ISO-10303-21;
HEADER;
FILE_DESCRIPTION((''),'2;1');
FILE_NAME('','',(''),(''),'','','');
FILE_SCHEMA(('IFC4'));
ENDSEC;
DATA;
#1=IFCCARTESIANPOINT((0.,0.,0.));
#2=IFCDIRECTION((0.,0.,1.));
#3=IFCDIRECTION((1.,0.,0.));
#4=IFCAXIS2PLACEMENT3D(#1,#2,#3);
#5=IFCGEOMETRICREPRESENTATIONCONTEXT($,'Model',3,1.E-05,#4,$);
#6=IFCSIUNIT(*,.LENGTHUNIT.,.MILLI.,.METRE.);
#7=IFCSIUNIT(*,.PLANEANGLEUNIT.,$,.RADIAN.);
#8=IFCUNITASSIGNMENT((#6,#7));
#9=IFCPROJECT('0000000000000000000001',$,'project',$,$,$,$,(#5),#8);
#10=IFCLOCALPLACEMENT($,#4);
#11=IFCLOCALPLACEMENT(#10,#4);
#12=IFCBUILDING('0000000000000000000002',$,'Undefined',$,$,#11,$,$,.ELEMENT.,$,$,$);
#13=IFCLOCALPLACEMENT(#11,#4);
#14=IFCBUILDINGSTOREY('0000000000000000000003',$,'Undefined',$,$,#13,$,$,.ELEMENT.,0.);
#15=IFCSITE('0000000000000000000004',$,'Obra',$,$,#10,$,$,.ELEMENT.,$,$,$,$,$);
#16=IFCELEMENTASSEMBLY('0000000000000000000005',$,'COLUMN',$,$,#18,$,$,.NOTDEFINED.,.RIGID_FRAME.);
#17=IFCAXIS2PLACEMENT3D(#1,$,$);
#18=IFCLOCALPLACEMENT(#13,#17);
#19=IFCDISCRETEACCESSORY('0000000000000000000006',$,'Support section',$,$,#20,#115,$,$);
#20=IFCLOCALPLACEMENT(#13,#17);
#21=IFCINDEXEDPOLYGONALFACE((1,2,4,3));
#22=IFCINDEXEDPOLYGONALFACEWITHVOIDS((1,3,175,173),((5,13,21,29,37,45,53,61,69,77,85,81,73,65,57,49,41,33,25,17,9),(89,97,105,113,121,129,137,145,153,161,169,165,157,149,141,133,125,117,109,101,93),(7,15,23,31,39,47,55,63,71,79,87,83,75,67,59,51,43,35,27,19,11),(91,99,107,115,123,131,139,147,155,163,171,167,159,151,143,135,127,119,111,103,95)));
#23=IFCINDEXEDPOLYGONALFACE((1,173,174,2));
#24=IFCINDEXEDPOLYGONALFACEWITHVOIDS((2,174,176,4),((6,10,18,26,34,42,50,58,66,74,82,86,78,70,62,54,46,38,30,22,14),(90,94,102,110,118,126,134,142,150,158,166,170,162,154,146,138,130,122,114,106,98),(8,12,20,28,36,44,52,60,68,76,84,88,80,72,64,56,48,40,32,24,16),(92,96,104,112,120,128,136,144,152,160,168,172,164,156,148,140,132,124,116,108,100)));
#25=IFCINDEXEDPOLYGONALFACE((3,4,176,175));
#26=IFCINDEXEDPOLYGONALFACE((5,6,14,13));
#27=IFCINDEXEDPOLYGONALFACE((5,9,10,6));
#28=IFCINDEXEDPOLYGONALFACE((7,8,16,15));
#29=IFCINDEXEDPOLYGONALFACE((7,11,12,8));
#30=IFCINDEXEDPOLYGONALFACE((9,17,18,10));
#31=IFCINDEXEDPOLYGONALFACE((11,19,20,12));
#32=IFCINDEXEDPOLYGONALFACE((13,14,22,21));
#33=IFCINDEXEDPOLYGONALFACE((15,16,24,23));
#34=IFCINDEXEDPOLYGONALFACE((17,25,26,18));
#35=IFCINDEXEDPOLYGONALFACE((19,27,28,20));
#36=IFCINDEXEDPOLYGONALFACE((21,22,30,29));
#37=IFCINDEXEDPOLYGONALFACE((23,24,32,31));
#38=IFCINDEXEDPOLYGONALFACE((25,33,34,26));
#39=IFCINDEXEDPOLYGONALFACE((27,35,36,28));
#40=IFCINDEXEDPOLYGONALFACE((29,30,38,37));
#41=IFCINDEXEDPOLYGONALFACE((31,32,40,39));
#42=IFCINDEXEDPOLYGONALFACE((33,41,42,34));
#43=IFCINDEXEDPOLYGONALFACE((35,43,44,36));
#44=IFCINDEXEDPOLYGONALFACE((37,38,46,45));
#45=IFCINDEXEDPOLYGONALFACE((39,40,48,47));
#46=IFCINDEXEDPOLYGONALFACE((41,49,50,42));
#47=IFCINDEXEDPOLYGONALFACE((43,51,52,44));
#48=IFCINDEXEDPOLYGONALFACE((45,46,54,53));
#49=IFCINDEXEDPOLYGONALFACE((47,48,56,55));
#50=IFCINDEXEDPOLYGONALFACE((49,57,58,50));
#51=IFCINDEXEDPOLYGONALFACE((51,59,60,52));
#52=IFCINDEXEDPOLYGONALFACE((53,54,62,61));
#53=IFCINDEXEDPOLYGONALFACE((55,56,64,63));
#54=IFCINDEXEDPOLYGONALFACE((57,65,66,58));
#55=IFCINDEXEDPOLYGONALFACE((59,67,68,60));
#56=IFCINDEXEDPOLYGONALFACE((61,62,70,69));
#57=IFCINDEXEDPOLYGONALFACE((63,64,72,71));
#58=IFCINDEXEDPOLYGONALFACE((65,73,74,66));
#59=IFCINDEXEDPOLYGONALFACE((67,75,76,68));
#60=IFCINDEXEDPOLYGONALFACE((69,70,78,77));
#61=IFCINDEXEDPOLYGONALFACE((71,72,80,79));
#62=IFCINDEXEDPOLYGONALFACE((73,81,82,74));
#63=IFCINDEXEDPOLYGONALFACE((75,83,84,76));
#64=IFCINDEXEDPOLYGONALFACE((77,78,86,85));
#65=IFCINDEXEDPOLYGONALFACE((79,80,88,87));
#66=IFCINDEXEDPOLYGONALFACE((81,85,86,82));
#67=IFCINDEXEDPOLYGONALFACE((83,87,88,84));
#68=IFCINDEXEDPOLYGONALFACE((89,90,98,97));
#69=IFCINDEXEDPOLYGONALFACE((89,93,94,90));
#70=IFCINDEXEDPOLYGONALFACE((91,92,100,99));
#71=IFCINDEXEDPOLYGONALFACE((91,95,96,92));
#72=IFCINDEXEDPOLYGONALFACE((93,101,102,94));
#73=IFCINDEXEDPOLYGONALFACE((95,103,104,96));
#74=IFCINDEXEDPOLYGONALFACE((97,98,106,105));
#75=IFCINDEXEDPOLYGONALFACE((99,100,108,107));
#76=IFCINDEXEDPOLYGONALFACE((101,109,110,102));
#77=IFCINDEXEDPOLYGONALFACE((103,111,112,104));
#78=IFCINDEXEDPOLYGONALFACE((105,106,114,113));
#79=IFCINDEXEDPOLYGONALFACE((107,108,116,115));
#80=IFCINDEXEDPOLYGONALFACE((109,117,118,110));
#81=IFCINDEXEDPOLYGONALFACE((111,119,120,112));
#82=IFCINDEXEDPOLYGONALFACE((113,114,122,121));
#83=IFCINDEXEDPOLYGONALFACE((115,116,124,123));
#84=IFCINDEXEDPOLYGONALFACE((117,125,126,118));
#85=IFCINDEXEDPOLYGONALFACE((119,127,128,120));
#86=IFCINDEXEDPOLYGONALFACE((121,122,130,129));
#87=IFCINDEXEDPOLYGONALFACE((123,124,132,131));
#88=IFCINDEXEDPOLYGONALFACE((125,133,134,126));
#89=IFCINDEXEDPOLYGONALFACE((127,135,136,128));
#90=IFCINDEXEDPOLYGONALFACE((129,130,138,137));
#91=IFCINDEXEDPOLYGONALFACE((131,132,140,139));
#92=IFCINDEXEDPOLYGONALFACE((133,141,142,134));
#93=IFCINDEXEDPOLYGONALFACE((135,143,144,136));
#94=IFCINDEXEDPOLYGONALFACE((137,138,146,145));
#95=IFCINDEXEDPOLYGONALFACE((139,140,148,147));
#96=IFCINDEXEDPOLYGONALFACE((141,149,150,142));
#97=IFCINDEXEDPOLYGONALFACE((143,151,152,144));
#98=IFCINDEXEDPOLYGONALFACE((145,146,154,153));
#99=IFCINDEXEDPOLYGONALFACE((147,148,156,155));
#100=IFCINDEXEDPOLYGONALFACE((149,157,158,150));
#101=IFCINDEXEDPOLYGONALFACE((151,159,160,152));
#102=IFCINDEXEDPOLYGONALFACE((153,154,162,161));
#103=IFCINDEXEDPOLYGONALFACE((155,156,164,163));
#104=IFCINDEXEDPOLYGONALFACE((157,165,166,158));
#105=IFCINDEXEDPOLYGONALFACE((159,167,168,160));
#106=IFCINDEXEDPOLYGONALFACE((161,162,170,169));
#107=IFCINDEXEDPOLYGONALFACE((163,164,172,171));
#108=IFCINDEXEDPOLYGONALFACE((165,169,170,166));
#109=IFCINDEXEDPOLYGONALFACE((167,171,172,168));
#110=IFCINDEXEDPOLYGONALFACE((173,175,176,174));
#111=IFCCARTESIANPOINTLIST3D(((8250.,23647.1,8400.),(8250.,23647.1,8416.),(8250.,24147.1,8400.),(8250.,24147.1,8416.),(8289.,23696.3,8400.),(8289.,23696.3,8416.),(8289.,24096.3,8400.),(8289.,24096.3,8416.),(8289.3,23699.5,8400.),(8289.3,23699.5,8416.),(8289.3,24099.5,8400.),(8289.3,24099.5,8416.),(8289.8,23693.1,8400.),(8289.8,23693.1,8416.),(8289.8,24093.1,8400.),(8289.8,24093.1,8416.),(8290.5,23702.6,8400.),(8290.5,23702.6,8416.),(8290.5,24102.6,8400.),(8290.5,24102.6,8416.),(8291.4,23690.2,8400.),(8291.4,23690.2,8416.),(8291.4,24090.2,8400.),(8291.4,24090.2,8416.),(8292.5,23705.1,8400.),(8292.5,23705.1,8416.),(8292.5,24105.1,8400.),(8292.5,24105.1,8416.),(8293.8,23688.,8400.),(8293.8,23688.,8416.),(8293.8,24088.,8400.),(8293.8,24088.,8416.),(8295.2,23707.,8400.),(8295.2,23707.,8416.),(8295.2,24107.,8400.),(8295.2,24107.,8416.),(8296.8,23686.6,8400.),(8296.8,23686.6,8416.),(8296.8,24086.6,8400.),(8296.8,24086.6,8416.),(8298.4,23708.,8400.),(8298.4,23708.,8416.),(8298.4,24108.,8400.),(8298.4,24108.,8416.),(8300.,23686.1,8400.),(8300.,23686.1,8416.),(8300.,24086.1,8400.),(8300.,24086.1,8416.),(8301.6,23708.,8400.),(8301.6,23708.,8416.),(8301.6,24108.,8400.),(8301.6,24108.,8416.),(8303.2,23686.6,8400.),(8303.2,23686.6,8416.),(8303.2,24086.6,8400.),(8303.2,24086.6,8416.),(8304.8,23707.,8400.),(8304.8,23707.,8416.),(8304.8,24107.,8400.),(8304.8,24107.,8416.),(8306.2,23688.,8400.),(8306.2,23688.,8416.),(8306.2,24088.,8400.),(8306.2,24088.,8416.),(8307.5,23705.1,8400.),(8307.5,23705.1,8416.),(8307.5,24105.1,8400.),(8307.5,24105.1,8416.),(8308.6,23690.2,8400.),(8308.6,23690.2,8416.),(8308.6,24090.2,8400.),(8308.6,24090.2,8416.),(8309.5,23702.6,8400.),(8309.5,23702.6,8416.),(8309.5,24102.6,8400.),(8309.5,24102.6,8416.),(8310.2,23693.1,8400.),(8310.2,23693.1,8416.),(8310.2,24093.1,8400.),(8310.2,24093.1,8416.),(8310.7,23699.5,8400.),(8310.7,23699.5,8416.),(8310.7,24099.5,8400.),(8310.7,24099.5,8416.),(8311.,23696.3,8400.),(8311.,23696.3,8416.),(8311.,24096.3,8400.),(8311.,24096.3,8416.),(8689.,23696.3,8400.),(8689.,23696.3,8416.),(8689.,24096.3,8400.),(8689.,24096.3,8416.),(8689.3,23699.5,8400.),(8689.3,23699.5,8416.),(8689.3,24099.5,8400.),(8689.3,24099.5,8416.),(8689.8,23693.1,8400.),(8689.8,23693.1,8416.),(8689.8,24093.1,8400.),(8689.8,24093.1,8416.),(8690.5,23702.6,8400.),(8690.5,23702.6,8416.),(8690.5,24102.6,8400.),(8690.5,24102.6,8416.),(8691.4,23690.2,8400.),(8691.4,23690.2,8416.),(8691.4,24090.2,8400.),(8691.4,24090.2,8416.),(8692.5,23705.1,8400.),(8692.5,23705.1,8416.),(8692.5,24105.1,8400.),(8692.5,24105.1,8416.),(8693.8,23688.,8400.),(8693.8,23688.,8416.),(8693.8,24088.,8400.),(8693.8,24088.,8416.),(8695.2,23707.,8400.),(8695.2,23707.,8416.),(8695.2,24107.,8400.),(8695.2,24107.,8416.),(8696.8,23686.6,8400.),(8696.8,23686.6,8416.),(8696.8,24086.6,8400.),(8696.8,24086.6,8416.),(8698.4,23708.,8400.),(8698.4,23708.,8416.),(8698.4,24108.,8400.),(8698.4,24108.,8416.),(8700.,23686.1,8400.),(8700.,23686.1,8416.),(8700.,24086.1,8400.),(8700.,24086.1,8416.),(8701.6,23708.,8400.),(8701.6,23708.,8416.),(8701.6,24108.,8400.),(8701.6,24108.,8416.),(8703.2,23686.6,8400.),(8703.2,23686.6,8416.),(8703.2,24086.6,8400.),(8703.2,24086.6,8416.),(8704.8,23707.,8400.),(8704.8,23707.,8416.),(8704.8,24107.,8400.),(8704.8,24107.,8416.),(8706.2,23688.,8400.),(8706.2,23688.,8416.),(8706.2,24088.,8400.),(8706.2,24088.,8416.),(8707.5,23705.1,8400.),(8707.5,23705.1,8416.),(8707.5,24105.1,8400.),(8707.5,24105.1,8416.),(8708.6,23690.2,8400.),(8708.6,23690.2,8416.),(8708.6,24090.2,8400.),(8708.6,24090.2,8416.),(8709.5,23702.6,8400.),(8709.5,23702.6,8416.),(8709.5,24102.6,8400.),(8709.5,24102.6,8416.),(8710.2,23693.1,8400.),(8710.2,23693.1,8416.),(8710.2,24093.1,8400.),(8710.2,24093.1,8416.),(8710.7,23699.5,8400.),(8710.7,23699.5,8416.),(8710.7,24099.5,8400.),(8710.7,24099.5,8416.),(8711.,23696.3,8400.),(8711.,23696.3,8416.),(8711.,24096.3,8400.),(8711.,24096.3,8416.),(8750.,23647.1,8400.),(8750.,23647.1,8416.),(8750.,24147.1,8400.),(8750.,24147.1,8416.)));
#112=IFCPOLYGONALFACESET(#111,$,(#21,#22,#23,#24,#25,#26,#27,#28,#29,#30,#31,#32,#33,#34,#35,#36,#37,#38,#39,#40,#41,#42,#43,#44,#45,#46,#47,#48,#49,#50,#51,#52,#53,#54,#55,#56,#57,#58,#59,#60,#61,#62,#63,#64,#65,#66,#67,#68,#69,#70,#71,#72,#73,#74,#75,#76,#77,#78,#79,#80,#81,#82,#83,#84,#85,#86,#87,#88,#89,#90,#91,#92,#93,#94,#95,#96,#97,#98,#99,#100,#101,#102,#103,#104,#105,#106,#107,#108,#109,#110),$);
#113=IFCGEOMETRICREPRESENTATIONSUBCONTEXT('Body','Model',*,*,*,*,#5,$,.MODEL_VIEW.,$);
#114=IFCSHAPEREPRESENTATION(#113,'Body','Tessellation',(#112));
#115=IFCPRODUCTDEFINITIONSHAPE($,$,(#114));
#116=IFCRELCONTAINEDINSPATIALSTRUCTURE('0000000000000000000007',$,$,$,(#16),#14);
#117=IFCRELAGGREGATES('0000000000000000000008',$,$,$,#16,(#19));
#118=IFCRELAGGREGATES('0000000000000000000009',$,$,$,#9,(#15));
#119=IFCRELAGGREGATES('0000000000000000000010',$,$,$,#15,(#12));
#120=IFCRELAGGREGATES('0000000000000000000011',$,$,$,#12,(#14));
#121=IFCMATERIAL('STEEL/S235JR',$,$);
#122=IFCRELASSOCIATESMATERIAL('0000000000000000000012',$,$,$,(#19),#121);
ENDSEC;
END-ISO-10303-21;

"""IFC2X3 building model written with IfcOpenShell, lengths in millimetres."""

from ifc_helpers import new_model, si_unit, frame, origin_with_axes, origin_2d_with_axis, place, context, subcontext, project, spatial, rectangle, circle, extrude, source, transform, mapped, material, element, aggregate, save


model = new_model("IFC2X3")

# Units and contexts
model_context = context("Model", 3, precision=1e-05, world=origin_with_axes())
body_context = subcontext(model_context, "Body", "Model", "MODEL_VIEW")
ifc_project = project(units=[si_unit("LENGTHUNIT", "METRE", prefix="MILLI"), si_unit("PLANEANGLEUNIT", "RADIAN")], contexts=[model_context])

# Site, building, storey
site_placement = place(None, origin_with_axes())
site = spatial("IfcSite", under=ifc_project, at=site_placement, Name="Obra", CompositionType="ELEMENT")
building_placement = place(site_placement, origin_with_axes())
building = spatial("IfcBuilding", under=site, at=building_placement, Name="Undefined", CompositionType="ELEMENT")
storey_placement = place(building_placement, origin_with_axes())
storey = spatial("IfcBuildingStorey", under=building, at=storey_placement, Name="Undefined", CompositionType="ELEMENT", Elevation=0.0)

# Element assembly
assembly_1_placement = place(storey_placement, origin_with_axes())
assembly_1 = element("IfcElementAssembly", 1, at=assembly_1_placement, inside=storey, Name="COLUMN", AssemblyPlace="NOTDEFINED", PredefinedType="RIGID_FRAME")
ifc_material_1 = material(Name="STEEL/S235JR")

# Discrete accessory, opening
discrete_accessory_1_placement = place(assembly_1_placement, frame((8500.0, 23647.1, 8408.0), z_axis=(-1.0, 0.0, 0.0), x_axis=(0.0, 1.0, 0.0)))
discrete_accessory_1 = element("IfcDiscreteAccessory", 2, at=discrete_accessory_1_placement, material=ifc_material_1, Name="Support section", context=body_context, shape_type="SweptSolid", body=[
    extrude(rectangle(XDim=16.0, YDim=500.0, at=origin_2d_with_axis()), frame((500.0, 0.0, 0.0), z_axis=(-1.0, 0.0, 0.0), x_axis=(0.0, -1.0, 0.0)), (0.0, 0.0, 1.0), 500.0),
])
shared_shape_1 = source(origin_with_axes(), body_context, "Body", "SweptSolid", [
    extrude(circle(Radius=11.0, at=origin_2d_with_axis()), frame((0.0, -0.1, 0.0), z_axis=(0.0, 1.0, 0.0), x_axis=(1.0, 0.0, 0.0)), (0.0, 0.0, 1.0), 16.2),
])
opening_1_placement = place(assembly_1_placement, frame((8500.0, 24100.1, 8416.0), z_axis=(1.0, 0.0, 0.0), x_axis=(0.0, -1.0, 0.0)))
element("IfcOpeningElement", 3, at=opening_1_placement, cuts=discrete_accessory_1, ObjectType="Opening", context=body_context, shape_type="MappedRepresentation", body=[
    mapped(shared_shape_1, transform((3.0, 0.0, 200.0))),
    mapped(shared_shape_1, transform((3.0, 0.0, -200.0))),
    mapped(shared_shape_1, transform((403.0, 0.0, 200.0))),
    mapped(shared_shape_1, transform((403.0, 0.0, -200.0))),
])
aggregate(assembly_1, [discrete_accessory_1])

save(model, "model.ifc")
